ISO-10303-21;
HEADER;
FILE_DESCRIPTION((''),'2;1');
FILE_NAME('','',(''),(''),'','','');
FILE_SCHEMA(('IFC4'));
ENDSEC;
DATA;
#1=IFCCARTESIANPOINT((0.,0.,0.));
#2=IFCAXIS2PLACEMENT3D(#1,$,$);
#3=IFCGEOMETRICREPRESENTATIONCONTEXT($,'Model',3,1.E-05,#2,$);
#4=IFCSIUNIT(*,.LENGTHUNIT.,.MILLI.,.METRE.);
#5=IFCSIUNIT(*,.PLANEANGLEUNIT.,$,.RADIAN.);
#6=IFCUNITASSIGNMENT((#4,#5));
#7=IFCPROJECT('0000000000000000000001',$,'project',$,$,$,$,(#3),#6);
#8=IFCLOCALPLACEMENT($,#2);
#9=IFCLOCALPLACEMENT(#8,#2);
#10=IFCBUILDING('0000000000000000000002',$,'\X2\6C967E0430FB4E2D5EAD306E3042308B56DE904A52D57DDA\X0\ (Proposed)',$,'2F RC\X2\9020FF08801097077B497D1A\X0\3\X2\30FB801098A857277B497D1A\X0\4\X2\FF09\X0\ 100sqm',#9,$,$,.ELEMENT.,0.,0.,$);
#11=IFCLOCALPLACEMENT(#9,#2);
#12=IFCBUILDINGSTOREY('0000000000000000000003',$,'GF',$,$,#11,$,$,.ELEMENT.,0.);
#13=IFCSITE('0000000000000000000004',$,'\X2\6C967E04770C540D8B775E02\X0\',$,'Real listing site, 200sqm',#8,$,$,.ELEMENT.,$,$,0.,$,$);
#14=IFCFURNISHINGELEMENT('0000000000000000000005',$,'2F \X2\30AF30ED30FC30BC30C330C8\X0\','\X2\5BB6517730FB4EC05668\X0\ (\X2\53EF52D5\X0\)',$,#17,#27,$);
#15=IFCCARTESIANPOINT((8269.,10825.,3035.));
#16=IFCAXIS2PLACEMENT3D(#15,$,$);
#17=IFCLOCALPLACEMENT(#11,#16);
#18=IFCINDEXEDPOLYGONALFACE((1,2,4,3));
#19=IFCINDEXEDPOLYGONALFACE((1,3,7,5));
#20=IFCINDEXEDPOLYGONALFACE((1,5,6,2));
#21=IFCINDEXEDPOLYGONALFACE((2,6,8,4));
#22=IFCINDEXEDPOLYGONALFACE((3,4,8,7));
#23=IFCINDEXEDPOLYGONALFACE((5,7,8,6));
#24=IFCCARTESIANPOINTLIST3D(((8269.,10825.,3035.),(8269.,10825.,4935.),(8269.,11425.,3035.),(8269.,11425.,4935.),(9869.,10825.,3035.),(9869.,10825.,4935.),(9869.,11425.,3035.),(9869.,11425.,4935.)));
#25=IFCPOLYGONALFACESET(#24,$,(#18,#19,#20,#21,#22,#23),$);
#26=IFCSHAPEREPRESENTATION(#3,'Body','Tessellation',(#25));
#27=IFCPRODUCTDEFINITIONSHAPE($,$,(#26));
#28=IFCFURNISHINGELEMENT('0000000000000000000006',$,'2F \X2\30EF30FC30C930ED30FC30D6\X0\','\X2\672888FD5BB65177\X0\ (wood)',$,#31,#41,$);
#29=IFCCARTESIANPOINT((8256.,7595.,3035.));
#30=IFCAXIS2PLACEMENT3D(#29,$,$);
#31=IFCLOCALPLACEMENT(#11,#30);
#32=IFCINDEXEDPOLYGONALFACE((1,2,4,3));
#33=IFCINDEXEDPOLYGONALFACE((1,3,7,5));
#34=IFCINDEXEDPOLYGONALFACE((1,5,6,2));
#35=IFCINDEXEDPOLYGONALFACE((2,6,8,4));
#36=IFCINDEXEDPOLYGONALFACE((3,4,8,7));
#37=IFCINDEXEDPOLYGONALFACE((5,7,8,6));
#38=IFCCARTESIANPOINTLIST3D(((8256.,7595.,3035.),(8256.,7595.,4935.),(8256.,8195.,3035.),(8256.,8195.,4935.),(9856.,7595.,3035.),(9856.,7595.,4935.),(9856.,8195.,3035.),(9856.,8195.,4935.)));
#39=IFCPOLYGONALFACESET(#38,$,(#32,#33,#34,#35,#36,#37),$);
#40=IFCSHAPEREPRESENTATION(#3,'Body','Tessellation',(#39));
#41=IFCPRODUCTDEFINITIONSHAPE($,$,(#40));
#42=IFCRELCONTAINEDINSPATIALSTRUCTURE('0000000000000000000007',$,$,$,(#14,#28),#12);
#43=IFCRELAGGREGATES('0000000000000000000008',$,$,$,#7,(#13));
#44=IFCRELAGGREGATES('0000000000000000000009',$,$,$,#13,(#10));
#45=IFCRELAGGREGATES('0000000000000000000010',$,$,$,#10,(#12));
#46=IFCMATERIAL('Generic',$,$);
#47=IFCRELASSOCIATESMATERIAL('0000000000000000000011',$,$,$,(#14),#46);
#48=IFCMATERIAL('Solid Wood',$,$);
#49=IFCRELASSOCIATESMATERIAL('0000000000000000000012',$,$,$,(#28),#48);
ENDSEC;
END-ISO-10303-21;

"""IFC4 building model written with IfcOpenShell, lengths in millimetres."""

from ifc_helpers import new_model, si_unit, frame, frame_2d, origin, place, context, project, spatial, rectangle, extrude, material, element, save


model = new_model("IFC4")

# Units and contexts
model_context = context("Model", 3, precision=1e-05, world=origin())
ifc_project = project(units=[si_unit("LENGTHUNIT", "METRE", prefix="MILLI"), si_unit("PLANEANGLEUNIT", "RADIAN")], contexts=[model_context])

# Site, building, storey
site_placement = place(None, origin())
site = spatial("IfcSite", under=ifc_project, at=site_placement, Name="沖縄県名護市", ObjectType="Real listing site, 200sqm", CompositionType="ELEMENT", RefElevation=0.0)
building_placement = place(site_placement, origin())
building = spatial("IfcBuilding", under=site, at=building_placement, Name="沖縄・中庭のある回遊動線 (Proposed)", ObjectType="2F RC造（耐震等級3・耐風圧等級4） 100sqm", CompositionType="ELEMENT", ElevationOfRefHeight=0.0, ElevationOfTerrain=0.0)
storey_placement = place(building_placement, origin())
storey = spatial("IfcBuildingStorey", under=building, at=storey_placement, Name="GF", CompositionType="ELEMENT", Elevation=0.0)

# Shared definitions
ifc_material_1 = material(Name="Solid Wood")

# Shared definitions
ifc_material_2 = material(Name="Generic")

# Furnishing elements
furnishing_1_placement = place(storey_placement, frame((8269.0, 10825.0, 3035.0)))
element("IfcFurnishingElement", 1, at=furnishing_1_placement, inside=storey, material=ifc_material_2, Name="2F クローゼット", Description="家具・什器 (可動)", context=model_context, shape_type="SweptSolid", body=[
    extrude(rectangle(XDim=1600.0, YDim=600.0, at=frame_2d((800.0, 300.0))), frame((8269.0, 10825.0, 3035.0)), (0.0, 0.0, 1.0), 1900.0),
])
furnishing_2_placement = place(storey_placement, frame((8256.0, 7595.0, 3035.0)))
element("IfcFurnishingElement", 2, at=furnishing_2_placement, inside=storey, material=ifc_material_1, Name="2F ワードローブ", Description="木製家具 (wood)", context=model_context, shape_type="SweptSolid", body=[
    extrude(rectangle(XDim=1600.0, YDim=600.0, at=frame_2d((800.0, 300.0))), frame((8256.0, 7595.0, 3035.0)), (0.0, 0.0, 1.0), 1900.0),
])

save(model, "model.ifc")
